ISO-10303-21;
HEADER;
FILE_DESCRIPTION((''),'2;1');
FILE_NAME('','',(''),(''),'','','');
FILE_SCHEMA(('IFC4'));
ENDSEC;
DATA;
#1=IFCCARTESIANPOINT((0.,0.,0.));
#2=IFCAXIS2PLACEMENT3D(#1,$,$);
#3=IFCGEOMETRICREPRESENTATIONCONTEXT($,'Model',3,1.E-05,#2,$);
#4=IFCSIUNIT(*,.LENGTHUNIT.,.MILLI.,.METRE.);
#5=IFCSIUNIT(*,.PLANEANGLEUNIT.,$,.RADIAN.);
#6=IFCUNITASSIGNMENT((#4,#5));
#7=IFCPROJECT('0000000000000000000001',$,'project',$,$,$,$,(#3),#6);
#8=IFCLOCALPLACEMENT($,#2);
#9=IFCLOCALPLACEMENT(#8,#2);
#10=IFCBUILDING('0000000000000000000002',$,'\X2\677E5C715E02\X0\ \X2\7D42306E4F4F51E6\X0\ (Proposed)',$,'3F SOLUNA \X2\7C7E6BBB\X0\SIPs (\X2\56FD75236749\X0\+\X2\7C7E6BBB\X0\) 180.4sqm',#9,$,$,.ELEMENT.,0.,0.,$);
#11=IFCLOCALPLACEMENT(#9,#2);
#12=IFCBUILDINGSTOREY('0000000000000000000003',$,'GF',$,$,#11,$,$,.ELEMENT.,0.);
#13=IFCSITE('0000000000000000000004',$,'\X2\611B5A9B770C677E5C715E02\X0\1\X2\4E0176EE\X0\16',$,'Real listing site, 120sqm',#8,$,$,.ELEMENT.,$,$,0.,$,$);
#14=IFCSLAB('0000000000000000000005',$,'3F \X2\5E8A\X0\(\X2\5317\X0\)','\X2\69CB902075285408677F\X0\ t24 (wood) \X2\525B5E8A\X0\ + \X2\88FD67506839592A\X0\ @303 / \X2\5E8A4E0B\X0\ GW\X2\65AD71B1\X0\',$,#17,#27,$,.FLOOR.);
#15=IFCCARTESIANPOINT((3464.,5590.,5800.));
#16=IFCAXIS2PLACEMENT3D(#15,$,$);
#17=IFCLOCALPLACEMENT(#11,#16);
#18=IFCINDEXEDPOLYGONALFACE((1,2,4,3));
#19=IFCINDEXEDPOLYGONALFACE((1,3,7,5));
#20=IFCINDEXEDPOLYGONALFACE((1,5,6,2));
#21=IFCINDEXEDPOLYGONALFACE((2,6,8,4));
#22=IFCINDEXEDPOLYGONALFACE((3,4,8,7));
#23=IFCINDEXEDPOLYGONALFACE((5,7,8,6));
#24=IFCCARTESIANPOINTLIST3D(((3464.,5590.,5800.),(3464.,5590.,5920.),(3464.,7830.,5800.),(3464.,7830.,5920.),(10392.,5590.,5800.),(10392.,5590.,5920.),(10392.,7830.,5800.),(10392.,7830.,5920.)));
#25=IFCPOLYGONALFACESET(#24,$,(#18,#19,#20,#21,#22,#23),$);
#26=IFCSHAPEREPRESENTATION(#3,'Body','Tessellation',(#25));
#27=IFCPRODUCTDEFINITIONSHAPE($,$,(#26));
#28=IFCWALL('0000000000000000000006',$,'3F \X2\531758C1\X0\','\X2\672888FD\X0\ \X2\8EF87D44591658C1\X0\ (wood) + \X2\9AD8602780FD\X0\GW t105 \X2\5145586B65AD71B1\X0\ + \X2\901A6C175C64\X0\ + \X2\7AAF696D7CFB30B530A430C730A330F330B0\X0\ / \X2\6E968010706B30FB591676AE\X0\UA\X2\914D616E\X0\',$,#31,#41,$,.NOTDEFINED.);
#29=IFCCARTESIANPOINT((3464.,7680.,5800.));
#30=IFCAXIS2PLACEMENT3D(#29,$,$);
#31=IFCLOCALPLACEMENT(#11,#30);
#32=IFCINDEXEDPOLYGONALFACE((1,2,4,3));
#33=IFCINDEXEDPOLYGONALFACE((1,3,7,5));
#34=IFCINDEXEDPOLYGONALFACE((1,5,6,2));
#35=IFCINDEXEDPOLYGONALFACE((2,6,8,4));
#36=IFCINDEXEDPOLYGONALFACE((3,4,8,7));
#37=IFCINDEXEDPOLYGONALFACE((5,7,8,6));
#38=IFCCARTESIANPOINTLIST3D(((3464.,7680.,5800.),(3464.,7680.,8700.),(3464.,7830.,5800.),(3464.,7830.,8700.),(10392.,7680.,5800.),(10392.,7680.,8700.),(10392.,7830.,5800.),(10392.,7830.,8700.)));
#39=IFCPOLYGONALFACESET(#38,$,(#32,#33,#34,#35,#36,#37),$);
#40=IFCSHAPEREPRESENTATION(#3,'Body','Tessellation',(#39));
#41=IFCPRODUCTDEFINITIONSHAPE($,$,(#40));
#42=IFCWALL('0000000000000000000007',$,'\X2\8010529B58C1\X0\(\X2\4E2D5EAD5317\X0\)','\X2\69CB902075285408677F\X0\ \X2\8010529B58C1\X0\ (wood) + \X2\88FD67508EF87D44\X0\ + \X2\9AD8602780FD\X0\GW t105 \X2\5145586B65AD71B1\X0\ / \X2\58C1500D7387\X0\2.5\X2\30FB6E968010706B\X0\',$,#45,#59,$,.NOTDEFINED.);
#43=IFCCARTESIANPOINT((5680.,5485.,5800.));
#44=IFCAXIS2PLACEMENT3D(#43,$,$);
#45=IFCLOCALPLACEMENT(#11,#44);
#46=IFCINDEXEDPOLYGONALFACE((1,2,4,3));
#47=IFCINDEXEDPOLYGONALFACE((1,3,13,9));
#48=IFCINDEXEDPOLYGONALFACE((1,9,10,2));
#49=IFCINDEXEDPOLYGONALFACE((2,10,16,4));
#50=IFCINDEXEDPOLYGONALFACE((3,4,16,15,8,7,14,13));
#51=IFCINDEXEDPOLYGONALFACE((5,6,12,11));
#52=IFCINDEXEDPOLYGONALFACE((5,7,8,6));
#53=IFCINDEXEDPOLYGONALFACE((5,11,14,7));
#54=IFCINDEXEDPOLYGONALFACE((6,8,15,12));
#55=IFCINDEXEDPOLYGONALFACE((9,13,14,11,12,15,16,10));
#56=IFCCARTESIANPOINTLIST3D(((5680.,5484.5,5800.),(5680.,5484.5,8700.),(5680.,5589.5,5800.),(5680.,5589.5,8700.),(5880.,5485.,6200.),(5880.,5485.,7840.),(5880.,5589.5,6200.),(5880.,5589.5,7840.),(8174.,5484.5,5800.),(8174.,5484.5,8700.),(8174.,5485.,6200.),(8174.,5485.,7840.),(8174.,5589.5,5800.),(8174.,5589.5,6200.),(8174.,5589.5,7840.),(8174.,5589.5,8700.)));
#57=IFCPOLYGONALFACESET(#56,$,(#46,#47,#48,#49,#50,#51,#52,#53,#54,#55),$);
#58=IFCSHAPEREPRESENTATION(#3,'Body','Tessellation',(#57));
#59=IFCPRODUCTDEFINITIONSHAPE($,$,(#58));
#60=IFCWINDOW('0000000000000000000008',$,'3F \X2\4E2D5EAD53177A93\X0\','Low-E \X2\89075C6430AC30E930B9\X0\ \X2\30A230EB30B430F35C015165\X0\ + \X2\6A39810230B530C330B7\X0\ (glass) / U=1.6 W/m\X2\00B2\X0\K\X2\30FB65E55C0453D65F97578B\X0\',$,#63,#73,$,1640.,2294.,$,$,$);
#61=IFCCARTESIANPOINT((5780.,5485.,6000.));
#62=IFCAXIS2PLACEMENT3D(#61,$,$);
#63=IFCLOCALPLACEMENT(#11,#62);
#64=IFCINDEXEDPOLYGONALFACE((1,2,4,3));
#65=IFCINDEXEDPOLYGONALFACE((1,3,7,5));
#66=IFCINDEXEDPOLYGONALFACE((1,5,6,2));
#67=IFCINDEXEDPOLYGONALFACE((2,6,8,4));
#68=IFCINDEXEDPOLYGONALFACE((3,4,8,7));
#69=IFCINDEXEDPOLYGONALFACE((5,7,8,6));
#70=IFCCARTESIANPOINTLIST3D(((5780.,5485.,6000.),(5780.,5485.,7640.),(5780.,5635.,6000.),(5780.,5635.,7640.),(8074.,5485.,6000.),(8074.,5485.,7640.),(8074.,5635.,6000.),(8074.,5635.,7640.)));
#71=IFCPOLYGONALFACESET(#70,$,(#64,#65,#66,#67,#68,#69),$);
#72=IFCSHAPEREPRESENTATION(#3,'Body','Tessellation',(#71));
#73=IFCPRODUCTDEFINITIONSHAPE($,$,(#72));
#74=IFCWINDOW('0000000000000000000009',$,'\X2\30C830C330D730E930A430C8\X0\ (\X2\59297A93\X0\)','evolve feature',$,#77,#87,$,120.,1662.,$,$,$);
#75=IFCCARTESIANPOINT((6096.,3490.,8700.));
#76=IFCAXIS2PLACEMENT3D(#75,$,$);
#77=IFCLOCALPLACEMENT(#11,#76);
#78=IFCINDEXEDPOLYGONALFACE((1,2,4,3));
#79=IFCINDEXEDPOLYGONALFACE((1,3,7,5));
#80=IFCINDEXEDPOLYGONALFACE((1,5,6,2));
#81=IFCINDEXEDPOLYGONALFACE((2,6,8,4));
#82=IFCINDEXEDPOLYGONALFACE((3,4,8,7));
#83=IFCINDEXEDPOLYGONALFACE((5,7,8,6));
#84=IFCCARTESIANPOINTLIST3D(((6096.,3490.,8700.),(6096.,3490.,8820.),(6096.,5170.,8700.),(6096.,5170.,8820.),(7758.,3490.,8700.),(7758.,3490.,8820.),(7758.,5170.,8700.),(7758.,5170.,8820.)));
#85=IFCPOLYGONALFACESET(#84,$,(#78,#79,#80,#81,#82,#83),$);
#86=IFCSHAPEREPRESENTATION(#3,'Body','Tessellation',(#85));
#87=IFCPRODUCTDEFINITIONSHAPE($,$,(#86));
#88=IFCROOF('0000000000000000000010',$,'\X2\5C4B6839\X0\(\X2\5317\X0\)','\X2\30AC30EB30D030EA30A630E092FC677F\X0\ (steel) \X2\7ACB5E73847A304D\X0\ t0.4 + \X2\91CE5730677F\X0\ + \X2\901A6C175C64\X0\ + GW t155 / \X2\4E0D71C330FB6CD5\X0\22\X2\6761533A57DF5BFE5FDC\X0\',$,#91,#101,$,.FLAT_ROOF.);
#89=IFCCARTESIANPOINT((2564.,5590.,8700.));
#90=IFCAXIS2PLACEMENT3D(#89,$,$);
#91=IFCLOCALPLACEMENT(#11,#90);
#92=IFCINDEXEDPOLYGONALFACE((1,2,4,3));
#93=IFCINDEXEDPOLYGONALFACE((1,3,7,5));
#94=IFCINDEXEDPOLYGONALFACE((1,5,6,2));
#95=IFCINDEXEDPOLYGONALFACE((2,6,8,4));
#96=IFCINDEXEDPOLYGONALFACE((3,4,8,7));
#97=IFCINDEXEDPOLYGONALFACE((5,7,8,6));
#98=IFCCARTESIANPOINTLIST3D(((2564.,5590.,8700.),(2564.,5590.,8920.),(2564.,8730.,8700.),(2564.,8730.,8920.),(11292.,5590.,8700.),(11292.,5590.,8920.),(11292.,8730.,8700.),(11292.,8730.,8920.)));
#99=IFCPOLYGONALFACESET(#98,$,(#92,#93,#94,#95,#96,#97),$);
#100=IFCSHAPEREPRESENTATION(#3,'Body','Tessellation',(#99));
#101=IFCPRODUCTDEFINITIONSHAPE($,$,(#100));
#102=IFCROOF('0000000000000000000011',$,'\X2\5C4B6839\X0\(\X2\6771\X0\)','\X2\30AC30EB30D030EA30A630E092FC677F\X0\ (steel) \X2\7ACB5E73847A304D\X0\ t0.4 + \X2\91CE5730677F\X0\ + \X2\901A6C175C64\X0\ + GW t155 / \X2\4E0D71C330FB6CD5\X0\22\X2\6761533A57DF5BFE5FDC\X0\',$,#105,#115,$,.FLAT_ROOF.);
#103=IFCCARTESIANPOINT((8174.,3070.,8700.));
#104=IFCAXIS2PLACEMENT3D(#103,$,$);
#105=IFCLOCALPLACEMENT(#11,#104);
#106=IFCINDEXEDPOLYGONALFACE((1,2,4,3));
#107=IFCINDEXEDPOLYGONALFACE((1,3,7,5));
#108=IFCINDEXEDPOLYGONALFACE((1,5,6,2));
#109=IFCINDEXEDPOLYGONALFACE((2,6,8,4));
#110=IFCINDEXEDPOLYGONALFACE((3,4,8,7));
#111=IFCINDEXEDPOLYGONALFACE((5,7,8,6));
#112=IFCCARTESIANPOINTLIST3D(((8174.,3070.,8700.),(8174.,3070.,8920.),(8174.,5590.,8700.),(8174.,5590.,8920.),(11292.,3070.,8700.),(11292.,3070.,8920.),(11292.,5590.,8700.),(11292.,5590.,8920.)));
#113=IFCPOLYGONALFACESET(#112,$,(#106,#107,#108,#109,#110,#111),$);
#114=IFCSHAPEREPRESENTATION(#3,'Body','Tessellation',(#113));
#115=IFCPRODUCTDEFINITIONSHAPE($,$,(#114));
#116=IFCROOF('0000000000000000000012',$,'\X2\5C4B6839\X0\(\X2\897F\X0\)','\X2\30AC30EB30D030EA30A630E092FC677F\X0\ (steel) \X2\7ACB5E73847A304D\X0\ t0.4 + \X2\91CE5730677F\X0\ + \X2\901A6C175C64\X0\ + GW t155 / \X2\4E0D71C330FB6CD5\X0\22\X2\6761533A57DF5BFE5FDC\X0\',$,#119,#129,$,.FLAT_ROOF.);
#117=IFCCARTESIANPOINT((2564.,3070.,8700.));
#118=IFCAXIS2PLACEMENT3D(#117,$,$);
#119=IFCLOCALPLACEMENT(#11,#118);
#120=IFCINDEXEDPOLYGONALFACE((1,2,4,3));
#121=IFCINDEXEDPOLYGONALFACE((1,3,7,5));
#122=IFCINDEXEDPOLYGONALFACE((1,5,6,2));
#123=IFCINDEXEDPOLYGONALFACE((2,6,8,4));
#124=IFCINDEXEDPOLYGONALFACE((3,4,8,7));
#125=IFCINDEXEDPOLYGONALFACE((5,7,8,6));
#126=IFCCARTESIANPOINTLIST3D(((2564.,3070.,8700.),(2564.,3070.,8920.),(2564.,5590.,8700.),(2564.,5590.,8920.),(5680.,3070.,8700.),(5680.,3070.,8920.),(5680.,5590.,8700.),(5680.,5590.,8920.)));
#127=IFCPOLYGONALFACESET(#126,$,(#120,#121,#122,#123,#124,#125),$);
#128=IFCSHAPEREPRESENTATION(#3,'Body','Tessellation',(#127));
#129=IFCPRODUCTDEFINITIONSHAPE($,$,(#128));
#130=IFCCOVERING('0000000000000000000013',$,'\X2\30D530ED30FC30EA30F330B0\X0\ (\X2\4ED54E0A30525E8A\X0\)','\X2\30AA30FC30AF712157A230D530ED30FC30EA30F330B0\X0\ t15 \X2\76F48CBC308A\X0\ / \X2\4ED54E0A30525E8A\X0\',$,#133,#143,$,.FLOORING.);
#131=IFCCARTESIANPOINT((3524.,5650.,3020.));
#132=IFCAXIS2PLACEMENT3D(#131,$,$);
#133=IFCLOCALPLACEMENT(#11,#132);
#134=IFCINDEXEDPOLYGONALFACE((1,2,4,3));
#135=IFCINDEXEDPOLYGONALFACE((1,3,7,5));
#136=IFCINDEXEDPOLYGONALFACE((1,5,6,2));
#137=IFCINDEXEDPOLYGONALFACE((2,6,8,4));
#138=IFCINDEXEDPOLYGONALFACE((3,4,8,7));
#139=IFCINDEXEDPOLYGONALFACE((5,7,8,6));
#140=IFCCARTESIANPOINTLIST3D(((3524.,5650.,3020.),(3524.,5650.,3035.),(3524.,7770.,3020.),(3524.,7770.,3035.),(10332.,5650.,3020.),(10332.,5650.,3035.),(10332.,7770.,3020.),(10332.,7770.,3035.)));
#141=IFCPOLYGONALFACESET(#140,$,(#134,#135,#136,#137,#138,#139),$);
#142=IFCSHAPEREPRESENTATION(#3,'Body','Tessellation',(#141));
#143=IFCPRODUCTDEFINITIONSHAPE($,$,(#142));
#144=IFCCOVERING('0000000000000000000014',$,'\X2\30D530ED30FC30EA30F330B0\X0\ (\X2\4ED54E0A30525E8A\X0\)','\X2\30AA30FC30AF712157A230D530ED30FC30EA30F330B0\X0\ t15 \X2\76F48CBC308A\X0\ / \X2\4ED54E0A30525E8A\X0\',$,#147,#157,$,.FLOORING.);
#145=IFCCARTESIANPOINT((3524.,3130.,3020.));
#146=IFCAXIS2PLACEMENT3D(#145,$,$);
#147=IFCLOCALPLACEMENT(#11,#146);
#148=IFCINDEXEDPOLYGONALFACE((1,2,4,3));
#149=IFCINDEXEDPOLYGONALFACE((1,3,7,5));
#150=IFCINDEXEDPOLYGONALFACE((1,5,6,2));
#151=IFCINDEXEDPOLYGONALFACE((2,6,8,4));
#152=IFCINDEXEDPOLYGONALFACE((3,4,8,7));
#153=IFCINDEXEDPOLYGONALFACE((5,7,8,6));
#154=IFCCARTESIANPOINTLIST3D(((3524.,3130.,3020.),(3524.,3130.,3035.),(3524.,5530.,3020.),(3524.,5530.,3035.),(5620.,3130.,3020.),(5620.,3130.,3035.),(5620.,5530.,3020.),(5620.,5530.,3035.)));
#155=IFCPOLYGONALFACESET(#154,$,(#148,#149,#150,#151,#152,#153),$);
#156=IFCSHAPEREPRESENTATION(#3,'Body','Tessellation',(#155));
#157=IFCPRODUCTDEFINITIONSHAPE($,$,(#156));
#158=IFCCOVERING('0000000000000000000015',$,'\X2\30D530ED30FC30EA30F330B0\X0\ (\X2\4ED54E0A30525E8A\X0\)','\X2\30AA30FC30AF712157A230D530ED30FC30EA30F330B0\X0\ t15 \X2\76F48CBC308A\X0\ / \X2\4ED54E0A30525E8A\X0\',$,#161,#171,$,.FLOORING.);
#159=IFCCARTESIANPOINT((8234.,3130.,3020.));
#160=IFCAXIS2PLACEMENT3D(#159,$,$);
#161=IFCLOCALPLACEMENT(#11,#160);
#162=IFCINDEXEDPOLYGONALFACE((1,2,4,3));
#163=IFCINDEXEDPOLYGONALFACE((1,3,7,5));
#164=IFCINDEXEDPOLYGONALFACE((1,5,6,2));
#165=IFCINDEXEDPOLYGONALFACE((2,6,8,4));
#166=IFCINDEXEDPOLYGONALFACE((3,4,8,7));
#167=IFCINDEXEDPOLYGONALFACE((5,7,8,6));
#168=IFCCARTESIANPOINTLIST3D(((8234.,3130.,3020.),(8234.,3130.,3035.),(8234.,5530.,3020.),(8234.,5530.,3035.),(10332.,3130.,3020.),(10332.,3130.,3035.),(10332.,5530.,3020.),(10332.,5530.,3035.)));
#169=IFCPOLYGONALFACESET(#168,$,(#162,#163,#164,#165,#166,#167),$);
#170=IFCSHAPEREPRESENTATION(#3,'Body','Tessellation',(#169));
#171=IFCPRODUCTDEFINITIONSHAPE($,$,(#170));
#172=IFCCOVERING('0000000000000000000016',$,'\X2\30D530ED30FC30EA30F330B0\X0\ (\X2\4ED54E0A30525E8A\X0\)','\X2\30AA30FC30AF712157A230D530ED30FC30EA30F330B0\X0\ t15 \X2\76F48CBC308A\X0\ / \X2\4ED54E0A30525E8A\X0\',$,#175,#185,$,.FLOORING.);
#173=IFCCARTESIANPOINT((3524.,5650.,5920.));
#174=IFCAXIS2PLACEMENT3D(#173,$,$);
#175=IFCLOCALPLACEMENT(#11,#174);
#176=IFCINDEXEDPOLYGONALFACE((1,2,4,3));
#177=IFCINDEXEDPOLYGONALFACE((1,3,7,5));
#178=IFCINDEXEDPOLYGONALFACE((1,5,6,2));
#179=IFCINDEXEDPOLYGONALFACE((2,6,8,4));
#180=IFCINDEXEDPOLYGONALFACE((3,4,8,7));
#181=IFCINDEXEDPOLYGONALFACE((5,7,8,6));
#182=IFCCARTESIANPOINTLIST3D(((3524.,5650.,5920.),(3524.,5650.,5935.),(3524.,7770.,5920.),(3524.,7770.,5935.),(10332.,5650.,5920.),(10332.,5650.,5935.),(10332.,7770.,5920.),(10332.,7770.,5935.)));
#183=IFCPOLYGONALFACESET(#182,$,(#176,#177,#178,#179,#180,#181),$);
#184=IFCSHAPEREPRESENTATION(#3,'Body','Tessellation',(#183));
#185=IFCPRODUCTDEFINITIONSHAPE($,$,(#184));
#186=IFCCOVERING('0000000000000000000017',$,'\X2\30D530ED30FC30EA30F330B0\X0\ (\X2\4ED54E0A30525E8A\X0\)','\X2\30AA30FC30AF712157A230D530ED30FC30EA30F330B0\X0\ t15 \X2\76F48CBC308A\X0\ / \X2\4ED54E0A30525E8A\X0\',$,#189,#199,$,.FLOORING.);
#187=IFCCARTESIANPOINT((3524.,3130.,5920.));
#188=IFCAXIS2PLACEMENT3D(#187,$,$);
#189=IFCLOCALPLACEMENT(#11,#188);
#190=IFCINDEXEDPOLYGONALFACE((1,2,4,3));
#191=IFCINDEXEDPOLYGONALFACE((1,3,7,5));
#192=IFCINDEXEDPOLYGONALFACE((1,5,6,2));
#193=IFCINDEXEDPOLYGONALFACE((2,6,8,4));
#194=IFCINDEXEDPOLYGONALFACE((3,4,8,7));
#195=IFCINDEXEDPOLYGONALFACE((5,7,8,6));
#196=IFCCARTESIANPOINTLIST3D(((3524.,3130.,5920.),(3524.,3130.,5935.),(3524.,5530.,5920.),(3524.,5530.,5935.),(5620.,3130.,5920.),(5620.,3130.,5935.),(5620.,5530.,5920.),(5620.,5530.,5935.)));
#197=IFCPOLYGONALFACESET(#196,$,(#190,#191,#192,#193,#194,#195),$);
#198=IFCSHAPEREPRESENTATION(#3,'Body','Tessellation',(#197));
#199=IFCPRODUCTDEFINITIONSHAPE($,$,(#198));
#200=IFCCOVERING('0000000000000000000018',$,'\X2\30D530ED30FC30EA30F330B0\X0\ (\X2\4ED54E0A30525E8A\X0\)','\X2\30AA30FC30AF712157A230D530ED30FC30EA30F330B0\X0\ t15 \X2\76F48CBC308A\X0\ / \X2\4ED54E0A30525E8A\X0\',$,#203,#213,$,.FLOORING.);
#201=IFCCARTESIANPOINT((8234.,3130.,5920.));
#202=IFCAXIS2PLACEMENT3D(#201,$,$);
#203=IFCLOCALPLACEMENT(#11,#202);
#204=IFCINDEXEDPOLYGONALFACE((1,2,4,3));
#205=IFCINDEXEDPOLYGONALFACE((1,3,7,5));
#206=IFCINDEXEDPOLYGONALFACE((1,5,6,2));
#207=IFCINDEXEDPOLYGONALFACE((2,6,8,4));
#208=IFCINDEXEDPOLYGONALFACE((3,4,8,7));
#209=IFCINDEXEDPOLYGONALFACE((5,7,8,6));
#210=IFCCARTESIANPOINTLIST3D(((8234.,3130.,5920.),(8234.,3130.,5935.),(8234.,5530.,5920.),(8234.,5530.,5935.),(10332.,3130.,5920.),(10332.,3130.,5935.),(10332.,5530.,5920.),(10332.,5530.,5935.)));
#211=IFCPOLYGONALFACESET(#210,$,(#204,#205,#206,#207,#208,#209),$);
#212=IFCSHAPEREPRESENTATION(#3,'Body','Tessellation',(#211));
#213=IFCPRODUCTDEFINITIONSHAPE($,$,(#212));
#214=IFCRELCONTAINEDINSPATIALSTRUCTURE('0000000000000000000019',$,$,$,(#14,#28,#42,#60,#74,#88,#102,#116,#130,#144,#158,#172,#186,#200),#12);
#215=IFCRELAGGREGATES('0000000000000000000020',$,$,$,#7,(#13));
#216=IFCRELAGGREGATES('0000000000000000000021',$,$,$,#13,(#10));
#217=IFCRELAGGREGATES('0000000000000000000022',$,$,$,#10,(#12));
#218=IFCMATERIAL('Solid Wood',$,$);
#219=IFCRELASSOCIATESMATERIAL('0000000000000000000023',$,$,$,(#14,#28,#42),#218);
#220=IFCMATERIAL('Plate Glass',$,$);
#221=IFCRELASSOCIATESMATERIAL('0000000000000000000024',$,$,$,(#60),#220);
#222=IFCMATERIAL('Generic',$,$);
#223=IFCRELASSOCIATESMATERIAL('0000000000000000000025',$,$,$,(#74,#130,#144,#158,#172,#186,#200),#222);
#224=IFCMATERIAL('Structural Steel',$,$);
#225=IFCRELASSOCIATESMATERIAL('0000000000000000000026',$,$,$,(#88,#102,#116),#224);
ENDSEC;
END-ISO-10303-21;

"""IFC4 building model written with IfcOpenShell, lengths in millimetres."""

from ifc_helpers import new_model, si_unit, frame, frame_2d, origin, place, context, project, spatial, rectangle, extrude, material, element, fill, save


model = new_model("IFC4")

# Units and contexts
model_context = context("Model", 3, precision=1e-05, world=origin())
ifc_project = project(units=[si_unit("LENGTHUNIT", "METRE", prefix="MILLI"), si_unit("PLANEANGLEUNIT", "RADIAN")], contexts=[model_context])

# Site, building, storey
site_placement = place(None, origin())
site = spatial("IfcSite", under=ifc_project, at=site_placement, Name="愛媛県松山市1丁目16", ObjectType="Real listing site, 120sqm", CompositionType="ELEMENT", RefElevation=0.0)
building_placement = place(site_placement, origin())
building = spatial("IfcBuilding", under=site, at=building_placement, Name="松山市 終の住処 (Proposed)", ObjectType="3F SOLUNA 籾殻SIPs (国産杉+籾殻) 180.4sqm", CompositionType="ELEMENT", ElevationOfRefHeight=0.0, ElevationOfTerrain=0.0)
storey_placement = place(building_placement, origin())
storey = spatial("IfcBuildingStorey", under=building, at=storey_placement, Name="GF", CompositionType="ELEMENT", Elevation=0.0)

# Slab
ifc_material_1 = material(Name="Solid Wood")
slab_placement = place(storey_placement, frame((3464.0, 5590.0, 5800.0)))
element("IfcSlab", 1, at=slab_placement, inside=storey, material=ifc_material_1, Name="3F 床(北)", Description="構造用合板 t24 (wood) 剛床 + 製材根太 @303 / 床下 GW断熱", PredefinedType="FLOOR", context=model_context, shape_type="SweptSolid", body=[
    extrude(rectangle(XDim=6928.0, YDim=2240.0, at=frame_2d((3464.0, 1120.0))), frame((3464.0, 5590.0, 5800.0)), (0.0, 0.0, 1.0), 120.0),
])

# Wall
wall_1_placement = place(storey_placement, frame((3464.0, 7680.0, 5800.0)))
element("IfcWall", 2, at=wall_1_placement, inside=storey, material=ifc_material_1, Name="3F 北壁", Description="木製 軸組外壁 (wood) + 高性能GW t105 充填断熱 + 通気層 + 窯業系サイディング / 準耐火・外皮UA配慮", PredefinedType="NOTDEFINED", context=model_context, shape_type="SweptSolid", body=[
    extrude(rectangle(XDim=6928.0, YDim=150.0, at=frame_2d((3464.0, 75.0))), frame((3464.0, 7680.0, 5800.0)), (0.0, 0.0, 1.0), 2900.0),
])

# Wall, opening, window
wall_2_placement = place(storey_placement, frame((5680.0, 5485.0, 5800.0)))
wall_2 = element("IfcWall", 3, at=wall_2_placement, inside=storey, material=ifc_material_1, Name="耐力壁(中庭北)", Description="構造用合板 耐力壁 (wood) + 製材軸組 + 高性能GW t105 充填断熱 / 壁倍率2.5・準耐火", PredefinedType="NOTDEFINED", context=model_context, shape_type="SweptSolid", body=[
    extrude(rectangle(XDim=2494.0, YDim=105.0, at=frame_2d((1247.0, 52.0))), frame((5680.0, 5485.0, 5800.0)), (0.0, 0.0, 1.0), 2900.0),
])
opening_placement = place(storey_placement, frame((5780.0, 5485.0, 6000.0)))
opening = element("IfcOpeningElement", 4, at=opening_placement, cuts=wall_2, PredefinedType="NOTDEFINED", context=model_context, shape_type="SweptSolid", body=[
    extrude(rectangle(XDim=2294.0, YDim=150.0, at=frame_2d((1147.0, 75.0))), frame((5780.0, 5485.0, 6000.0)), (0.0, 0.0, 1.0), 1640.0),
])
ifc_material_2 = material(Name="Plate Glass")
window_1_placement = place(storey_placement, frame((5780.0, 5485.0, 6000.0)))
window_1 = element("IfcWindow", 5, at=window_1_placement, inside=storey, material=ifc_material_2, Name="3F 中庭北窓", Description="Low-E 複層ガラス アルゴン封入 + 樹脂サッシ (glass) / U=1.6 W/m²K・日射取得型", OverallHeight=1640.0, OverallWidth=2294.0, context=model_context, shape_type="SweptSolid", body=[
    extrude(rectangle(XDim=2294.0, YDim=150.0, at=frame_2d((1147.0, 75.0))), frame((5780.0, 5485.0, 6000.0)), (0.0, 0.0, 1.0), 1640.0),
])
fill(opening, window_1)

# Window
ifc_material_3 = material(Name="Generic")
window_2_placement = place(storey_placement, frame((6096.0, 3490.0, 8700.0)))
element("IfcWindow", 6, at=window_2_placement, inside=storey, material=ifc_material_3, Name="トップライト (天窓)", Description="evolve feature", OverallHeight=120.0, OverallWidth=1662.0, context=model_context, shape_type="SweptSolid", body=[
    extrude(rectangle(XDim=1662.0, YDim=1680.0, at=frame_2d((831.0, 840.0))), frame((6096.0, 3490.0, 8700.0)), (0.0, 0.0, 1.0), 120.0),
])

# Roofs
ifc_material_4 = material(Name="Structural Steel")
roof_1_placement = place(storey_placement, frame((2564.0, 5590.0, 8700.0)))
element("IfcRoof", 7, at=roof_1_placement, inside=storey, material=ifc_material_4, Name="屋根(北)", Description="ガルバリウム鋼板 (steel) 立平葺き t0.4 + 野地板 + 通気層 + GW t155 / 不燃・法22条区域対応", PredefinedType="FLAT_ROOF", context=model_context, shape_type="SweptSolid", body=[
    extrude(rectangle(XDim=8728.0, YDim=3140.0, at=frame_2d((4364.0, 1570.0))), frame((2564.0, 5590.0, 8700.0)), (0.0, 0.0, 1.0), 220.0),
])
roof_2_placement = place(storey_placement, frame((8174.0, 3070.0, 8700.0)))
element("IfcRoof", 8, at=roof_2_placement, inside=storey, material=ifc_material_4, Name="屋根(東)", Description="ガルバリウム鋼板 (steel) 立平葺き t0.4 + 野地板 + 通気層 + GW t155 / 不燃・法22条区域対応", PredefinedType="FLAT_ROOF", context=model_context, shape_type="SweptSolid", body=[
    extrude(rectangle(XDim=3118.0, YDim=2520.0, at=frame_2d((1559.0, 1260.0))), frame((8174.0, 3070.0, 8700.0)), (0.0, 0.0, 1.0), 220.0),
])
roof_3_placement = place(storey_placement, frame((2564.0, 3070.0, 8700.0)))
element("IfcRoof", 9, at=roof_3_placement, inside=storey, material=ifc_material_4, Name="屋根(西)", Description="ガルバリウム鋼板 (steel) 立平葺き t0.4 + 野地板 + 通気層 + GW t155 / 不燃・法22条区域対応", PredefinedType="FLAT_ROOF", context=model_context, shape_type="SweptSolid", body=[
    extrude(rectangle(XDim=3116.0, YDim=2520.0, at=frame_2d((1558.0, 1260.0))), frame((2564.0, 3070.0, 8700.0)), (0.0, 0.0, 1.0), 220.0),
])

# Coverings
covering_1_placement = place(storey_placement, frame((3524.0, 5650.0, 3020.0)))
element("IfcCovering", 10, at=covering_1_placement, inside=storey, material=ifc_material_3, Name="フローリング (仕上げ床)", Description="オーク無垢フローリング t15 直貼り / 仕上げ床", PredefinedType="FLOORING", context=model_context, shape_type="SweptSolid", body=[
    extrude(rectangle(XDim=6808.0, YDim=2120.0, at=frame_2d((3404.0, 1060.0))), frame((3524.0, 5650.0, 3020.0)), (0.0, 0.0, 1.0), 15.0),
])
covering_2_placement = place(storey_placement, frame((3524.0, 3130.0, 3020.0)))
element("IfcCovering", 11, at=covering_2_placement, inside=storey, material=ifc_material_3, Name="フローリング (仕上げ床)", Description="オーク無垢フローリング t15 直貼り / 仕上げ床", PredefinedType="FLOORING", context=model_context, shape_type="SweptSolid", body=[
    extrude(rectangle(XDim=2096.0, YDim=2400.0, at=frame_2d((1048.0, 1200.0))), frame((3524.0, 3130.0, 3020.0)), (0.0, 0.0, 1.0), 15.0),
])
covering_3_placement = place(storey_placement, frame((8234.0, 3130.0, 3020.0)))
element("IfcCovering", 12, at=covering_3_placement, inside=storey, material=ifc_material_3, Name="フローリング (仕上げ床)", Description="オーク無垢フローリング t15 直貼り / 仕上げ床", PredefinedType="FLOORING", context=model_context, shape_type="SweptSolid", body=[
    extrude(rectangle(XDim=2098.0, YDim=2400.0, at=frame_2d((1049.0, 1200.0))), frame((8234.0, 3130.0, 3020.0)), (0.0, 0.0, 1.0), 15.0),
])
covering_4_placement = place(storey_placement, frame((3524.0, 5650.0, 5920.0)))
element("IfcCovering", 13, at=covering_4_placement, inside=storey, material=ifc_material_3, Name="フローリング (仕上げ床)", Description="オーク無垢フローリング t15 直貼り / 仕上げ床", PredefinedType="FLOORING", context=model_context, shape_type="SweptSolid", body=[
    extrude(rectangle(XDim=6808.0, YDim=2120.0, at=frame_2d((3404.0, 1060.0))), frame((3524.0, 5650.0, 5920.0)), (0.0, 0.0, 1.0), 15.0),
])
covering_5_placement = place(storey_placement, frame((3524.0, 3130.0, 5920.0)))
element("IfcCovering", 14, at=covering_5_placement, inside=storey, material=ifc_material_3, Name="フローリング (仕上げ床)", Description="オーク無垢フローリング t15 直貼り / 仕上げ床", PredefinedType="FLOORING", context=model_context, shape_type="SweptSolid", body=[
    extrude(rectangle(XDim=2096.0, YDim=2400.0, at=frame_2d((1048.0, 1200.0))), frame((3524.0, 3130.0, 5920.0)), (0.0, 0.0, 1.0), 15.0),
])
covering_6_placement = place(storey_placement, frame((8234.0, 3130.0, 5920.0)))
element("IfcCovering", 15, at=covering_6_placement, inside=storey, material=ifc_material_3, Name="フローリング (仕上げ床)", Description="オーク無垢フローリング t15 直貼り / 仕上げ床", PredefinedType="FLOORING", context=model_context, shape_type="SweptSolid", body=[
    extrude(rectangle(XDim=2098.0, YDim=2400.0, at=frame_2d((1049.0, 1200.0))), frame((8234.0, 3130.0, 5920.0)), (0.0, 0.0, 1.0), 15.0),
])

save(model, "model.ifc")
